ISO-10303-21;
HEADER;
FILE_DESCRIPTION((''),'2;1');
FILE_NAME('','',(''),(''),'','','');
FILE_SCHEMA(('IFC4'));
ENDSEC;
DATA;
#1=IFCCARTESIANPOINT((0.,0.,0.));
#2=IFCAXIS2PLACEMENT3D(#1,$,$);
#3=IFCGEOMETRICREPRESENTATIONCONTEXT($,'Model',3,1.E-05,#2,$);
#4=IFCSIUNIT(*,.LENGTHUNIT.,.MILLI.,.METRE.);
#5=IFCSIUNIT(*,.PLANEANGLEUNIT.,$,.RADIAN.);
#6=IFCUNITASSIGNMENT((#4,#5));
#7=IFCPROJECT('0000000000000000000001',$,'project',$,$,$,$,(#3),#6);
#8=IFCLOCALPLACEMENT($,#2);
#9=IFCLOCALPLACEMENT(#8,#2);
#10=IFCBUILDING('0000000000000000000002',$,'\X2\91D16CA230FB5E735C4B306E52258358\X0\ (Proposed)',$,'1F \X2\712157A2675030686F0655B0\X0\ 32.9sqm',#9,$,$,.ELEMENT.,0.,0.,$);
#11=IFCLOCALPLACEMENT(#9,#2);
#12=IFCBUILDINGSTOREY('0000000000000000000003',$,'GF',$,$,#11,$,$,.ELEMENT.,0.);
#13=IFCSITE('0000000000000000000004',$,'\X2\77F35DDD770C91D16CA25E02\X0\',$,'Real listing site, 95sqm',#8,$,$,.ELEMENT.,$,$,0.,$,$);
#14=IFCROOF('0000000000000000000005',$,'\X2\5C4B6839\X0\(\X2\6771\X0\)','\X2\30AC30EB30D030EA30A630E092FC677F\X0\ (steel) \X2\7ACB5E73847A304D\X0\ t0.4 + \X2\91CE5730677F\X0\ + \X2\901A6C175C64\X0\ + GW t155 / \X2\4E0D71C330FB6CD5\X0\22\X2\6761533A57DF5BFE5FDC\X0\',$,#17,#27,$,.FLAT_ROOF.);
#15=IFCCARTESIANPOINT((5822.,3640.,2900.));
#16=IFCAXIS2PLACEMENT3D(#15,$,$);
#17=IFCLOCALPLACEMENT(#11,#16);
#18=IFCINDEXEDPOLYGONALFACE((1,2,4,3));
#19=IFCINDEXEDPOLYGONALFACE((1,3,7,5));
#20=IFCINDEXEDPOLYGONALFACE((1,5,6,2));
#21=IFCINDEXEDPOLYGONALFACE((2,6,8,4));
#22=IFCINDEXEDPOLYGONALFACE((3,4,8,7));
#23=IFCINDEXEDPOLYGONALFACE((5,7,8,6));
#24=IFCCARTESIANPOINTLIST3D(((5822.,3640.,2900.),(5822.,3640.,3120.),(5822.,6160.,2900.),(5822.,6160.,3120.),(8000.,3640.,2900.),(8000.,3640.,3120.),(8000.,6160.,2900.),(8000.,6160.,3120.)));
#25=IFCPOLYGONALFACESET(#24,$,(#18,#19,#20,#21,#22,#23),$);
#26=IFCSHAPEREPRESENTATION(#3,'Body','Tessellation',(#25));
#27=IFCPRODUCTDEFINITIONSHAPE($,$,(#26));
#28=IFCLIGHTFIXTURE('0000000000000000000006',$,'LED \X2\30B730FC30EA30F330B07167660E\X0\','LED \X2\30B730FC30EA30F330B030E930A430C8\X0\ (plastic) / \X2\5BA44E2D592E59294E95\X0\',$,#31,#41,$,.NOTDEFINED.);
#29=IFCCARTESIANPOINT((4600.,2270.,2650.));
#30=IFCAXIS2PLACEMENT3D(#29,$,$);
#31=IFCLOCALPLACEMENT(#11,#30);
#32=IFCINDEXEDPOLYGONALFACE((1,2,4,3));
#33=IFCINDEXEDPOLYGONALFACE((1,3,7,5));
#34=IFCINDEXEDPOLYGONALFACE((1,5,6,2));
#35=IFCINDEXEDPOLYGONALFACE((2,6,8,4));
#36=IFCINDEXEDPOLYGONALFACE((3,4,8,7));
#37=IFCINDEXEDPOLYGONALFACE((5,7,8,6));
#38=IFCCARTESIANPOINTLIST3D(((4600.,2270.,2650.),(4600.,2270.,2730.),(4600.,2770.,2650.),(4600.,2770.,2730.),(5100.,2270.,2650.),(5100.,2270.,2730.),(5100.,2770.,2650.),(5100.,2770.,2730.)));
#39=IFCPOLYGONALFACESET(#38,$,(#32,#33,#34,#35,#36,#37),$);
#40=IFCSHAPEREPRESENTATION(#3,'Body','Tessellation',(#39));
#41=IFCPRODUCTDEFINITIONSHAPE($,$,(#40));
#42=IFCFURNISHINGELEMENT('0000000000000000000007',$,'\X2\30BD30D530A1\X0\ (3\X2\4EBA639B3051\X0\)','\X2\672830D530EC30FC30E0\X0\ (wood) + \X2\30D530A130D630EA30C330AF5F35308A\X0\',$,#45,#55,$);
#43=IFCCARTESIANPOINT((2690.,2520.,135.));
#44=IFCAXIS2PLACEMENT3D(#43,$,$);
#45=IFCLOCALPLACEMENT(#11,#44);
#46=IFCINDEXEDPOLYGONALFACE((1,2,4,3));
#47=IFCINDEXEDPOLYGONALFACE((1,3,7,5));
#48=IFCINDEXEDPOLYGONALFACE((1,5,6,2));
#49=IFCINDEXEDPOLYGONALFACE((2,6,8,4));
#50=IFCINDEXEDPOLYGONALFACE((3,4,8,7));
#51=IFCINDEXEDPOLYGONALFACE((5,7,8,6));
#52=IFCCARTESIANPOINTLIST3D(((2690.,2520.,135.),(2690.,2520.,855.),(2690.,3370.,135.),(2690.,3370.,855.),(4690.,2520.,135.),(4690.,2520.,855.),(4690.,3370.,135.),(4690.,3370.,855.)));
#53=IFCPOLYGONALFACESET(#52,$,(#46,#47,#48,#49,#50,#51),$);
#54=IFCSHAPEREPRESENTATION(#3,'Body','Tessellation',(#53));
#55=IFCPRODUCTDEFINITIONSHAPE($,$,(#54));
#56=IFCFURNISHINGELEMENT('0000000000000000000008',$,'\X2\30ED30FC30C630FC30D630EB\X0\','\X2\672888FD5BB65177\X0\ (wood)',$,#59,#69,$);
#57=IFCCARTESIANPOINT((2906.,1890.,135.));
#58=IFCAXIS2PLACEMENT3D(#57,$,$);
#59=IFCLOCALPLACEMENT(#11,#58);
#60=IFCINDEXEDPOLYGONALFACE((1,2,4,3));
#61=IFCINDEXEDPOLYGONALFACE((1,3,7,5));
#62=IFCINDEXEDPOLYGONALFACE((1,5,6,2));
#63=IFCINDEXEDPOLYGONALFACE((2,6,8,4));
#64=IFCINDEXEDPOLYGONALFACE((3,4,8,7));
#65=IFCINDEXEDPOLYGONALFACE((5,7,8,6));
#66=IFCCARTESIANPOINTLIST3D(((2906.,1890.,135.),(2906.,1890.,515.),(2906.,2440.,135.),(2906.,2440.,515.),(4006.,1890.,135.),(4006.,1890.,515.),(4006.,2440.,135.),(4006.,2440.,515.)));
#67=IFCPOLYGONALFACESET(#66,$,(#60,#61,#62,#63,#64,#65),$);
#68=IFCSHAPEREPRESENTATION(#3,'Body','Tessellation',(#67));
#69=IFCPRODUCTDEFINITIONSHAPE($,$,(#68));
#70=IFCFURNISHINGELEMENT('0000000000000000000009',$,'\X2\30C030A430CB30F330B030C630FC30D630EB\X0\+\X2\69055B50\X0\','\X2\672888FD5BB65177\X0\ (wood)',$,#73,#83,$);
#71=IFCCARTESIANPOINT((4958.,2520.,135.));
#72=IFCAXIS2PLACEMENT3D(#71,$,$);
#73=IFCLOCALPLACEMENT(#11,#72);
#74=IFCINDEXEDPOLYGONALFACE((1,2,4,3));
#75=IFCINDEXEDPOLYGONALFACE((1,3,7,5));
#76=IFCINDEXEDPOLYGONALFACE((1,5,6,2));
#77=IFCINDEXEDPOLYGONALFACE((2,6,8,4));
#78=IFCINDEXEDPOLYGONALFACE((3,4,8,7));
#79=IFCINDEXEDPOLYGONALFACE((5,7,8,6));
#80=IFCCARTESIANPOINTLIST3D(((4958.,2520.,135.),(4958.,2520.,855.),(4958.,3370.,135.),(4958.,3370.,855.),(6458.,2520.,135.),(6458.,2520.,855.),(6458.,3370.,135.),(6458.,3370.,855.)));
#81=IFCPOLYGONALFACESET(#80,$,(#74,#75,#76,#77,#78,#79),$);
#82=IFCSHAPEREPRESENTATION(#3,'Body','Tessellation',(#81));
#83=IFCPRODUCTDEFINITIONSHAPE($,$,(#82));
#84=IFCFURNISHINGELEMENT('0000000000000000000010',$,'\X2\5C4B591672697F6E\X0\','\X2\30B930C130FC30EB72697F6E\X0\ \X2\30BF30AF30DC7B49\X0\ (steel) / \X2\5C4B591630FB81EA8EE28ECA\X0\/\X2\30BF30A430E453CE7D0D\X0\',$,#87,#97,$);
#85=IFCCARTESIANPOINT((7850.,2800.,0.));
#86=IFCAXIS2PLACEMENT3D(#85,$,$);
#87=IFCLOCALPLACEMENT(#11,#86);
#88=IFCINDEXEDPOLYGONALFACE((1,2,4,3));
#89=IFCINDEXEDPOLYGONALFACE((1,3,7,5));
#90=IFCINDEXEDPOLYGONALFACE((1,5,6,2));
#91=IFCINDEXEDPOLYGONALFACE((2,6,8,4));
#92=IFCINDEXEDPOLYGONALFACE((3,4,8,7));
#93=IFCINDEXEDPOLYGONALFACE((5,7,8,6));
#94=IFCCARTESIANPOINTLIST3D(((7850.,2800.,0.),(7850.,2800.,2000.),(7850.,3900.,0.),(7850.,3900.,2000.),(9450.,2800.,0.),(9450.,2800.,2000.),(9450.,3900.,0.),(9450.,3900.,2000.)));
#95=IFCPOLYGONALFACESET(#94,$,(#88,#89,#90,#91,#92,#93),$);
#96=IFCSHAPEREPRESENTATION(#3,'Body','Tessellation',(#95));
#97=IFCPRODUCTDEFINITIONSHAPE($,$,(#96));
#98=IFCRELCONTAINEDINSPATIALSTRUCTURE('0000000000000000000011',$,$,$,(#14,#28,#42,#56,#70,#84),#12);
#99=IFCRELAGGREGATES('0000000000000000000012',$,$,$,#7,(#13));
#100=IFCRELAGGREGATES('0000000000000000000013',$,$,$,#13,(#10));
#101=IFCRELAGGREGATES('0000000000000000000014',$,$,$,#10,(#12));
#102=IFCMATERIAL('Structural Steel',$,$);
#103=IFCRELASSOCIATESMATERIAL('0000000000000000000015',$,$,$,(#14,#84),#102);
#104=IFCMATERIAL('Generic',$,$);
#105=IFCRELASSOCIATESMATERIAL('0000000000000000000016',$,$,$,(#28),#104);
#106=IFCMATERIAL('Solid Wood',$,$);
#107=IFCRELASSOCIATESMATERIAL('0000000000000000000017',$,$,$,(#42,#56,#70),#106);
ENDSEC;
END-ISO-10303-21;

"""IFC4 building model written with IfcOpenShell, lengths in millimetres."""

from ifc_helpers import new_model, si_unit, frame, frame_2d, origin, place, context, project, spatial, rectangle, extrude, material, element, save


model = new_model("IFC4")

# Units and contexts
model_context = context("Model", 3, precision=1e-05, world=origin())
ifc_project = project(units=[si_unit("LENGTHUNIT", "METRE", prefix="MILLI"), si_unit("PLANEANGLEUNIT", "RADIAN")], contexts=[model_context])

# Site, building, storey
site_placement = place(None, origin())
site = spatial("IfcSite", under=ifc_project, at=site_placement, Name="石川県金沢市", ObjectType="Real listing site, 95sqm", CompositionType="ELEMENT", RefElevation=0.0)
building_placement = place(site_placement, origin())
building = spatial("IfcBuilding", under=site, at=building_placement, Name="金沢・平屋の別荘 (Proposed)", ObjectType="1F 無垢材と漆喰 32.9sqm", CompositionType="ELEMENT", ElevationOfRefHeight=0.0, ElevationOfTerrain=0.0)
storey_placement = place(building_placement, origin())
storey = spatial("IfcBuildingStorey", under=building, at=storey_placement, Name="GF", CompositionType="ELEMENT", Elevation=0.0)

# Shared definitions
ifc_material_1 = material(Name="Solid Wood")

# Roof
ifc_material_2 = material(Name="Structural Steel")
roof_1_placement = place(storey_placement, frame((5822.0, 3640.0, 2900.0)))
element("IfcRoof", 1, at=roof_1_placement, inside=storey, material=ifc_material_2, Name="屋根(東)", Description="ガルバリウム鋼板 (steel) 立平葺き t0.4 + 野地板 + 通気層 + GW t155 / 不燃・法22条区域対応", PredefinedType="FLAT_ROOF", context=model_context, shape_type="SweptSolid", body=[
    extrude(rectangle(XDim=2178.0, YDim=2520.0, at=frame_2d((1089.0, 1260.0))), frame((5822.0, 3640.0, 2900.0)), (0.0, 0.0, 1.0), 220.0),
])

# Light fixture
ifc_material_3 = material(Name="Generic")
light_fixture_placement = place(storey_placement, frame((4600.0, 2270.0, 2650.0)))
element("IfcLightFixture", 2, at=light_fixture_placement, inside=storey, material=ifc_material_3, Name="LED シーリング照明", Description="LED シーリングライト (plastic) / 室中央天井", PredefinedType="NOTDEFINED", context=model_context, shape_type="SweptSolid", body=[
    extrude(rectangle(XDim=500.0, YDim=500.0, at=frame_2d((250.0, 250.0))), frame((4600.0, 2270.0, 2650.0)), (0.0, 0.0, 1.0), 80.0),
])

# Furnishing elements
furnishing_1_placement = place(storey_placement, frame((2690.0, 2520.0, 135.0)))
element("IfcFurnishingElement", 3, at=furnishing_1_placement, inside=storey, material=ifc_material_1, Name="ソファ (3人掛け)", Description="木フレーム (wood) + ファブリック張り", context=model_context, shape_type="SweptSolid", body=[
    extrude(rectangle(XDim=2000.0, YDim=850.0, at=frame_2d((1000.0, 425.0))), frame((2690.0, 2520.0, 135.0)), (0.0, 0.0, 1.0), 720.0),
])
furnishing_2_placement = place(storey_placement, frame((2906.0, 1890.0, 135.0)))
element("IfcFurnishingElement", 4, at=furnishing_2_placement, inside=storey, material=ifc_material_1, Name="ローテーブル", Description="木製家具 (wood)", context=model_context, shape_type="SweptSolid", body=[
    extrude(rectangle(XDim=1100.0, YDim=550.0, at=frame_2d((550.0, 275.0))), frame((2906.0, 1890.0, 135.0)), (0.0, 0.0, 1.0), 380.0),
])
furnishing_3_placement = place(storey_placement, frame((4958.0, 2520.0, 135.0)))
element("IfcFurnishingElement", 5, at=furnishing_3_placement, inside=storey, material=ifc_material_1, Name="ダイニングテーブル+椅子", Description="木製家具 (wood)", context=model_context, shape_type="SweptSolid", body=[
    extrude(rectangle(XDim=1500.0, YDim=850.0, at=frame_2d((750.0, 425.0))), frame((4958.0, 2520.0, 135.0)), (0.0, 0.0, 1.0), 720.0),
])
furnishing_4_placement = place(storey_placement, frame((7850.0, 2800.0, 0.0)))
element("IfcFurnishingElement", 6, at=furnishing_4_placement, inside=storey, material=ifc_material_2, Name="屋外物置", Description="スチール物置 タクボ等 (steel) / 屋外・自転車/タイヤ収納", context=model_context, shape_type="SweptSolid", body=[
    extrude(rectangle(XDim=1600.0, YDim=1100.0, at=frame_2d((800.0, 550.0))), frame((7850.0, 2800.0, 0.0)), (0.0, 0.0, 1.0), 2000.0),
])

save(model, "model.ifc")
